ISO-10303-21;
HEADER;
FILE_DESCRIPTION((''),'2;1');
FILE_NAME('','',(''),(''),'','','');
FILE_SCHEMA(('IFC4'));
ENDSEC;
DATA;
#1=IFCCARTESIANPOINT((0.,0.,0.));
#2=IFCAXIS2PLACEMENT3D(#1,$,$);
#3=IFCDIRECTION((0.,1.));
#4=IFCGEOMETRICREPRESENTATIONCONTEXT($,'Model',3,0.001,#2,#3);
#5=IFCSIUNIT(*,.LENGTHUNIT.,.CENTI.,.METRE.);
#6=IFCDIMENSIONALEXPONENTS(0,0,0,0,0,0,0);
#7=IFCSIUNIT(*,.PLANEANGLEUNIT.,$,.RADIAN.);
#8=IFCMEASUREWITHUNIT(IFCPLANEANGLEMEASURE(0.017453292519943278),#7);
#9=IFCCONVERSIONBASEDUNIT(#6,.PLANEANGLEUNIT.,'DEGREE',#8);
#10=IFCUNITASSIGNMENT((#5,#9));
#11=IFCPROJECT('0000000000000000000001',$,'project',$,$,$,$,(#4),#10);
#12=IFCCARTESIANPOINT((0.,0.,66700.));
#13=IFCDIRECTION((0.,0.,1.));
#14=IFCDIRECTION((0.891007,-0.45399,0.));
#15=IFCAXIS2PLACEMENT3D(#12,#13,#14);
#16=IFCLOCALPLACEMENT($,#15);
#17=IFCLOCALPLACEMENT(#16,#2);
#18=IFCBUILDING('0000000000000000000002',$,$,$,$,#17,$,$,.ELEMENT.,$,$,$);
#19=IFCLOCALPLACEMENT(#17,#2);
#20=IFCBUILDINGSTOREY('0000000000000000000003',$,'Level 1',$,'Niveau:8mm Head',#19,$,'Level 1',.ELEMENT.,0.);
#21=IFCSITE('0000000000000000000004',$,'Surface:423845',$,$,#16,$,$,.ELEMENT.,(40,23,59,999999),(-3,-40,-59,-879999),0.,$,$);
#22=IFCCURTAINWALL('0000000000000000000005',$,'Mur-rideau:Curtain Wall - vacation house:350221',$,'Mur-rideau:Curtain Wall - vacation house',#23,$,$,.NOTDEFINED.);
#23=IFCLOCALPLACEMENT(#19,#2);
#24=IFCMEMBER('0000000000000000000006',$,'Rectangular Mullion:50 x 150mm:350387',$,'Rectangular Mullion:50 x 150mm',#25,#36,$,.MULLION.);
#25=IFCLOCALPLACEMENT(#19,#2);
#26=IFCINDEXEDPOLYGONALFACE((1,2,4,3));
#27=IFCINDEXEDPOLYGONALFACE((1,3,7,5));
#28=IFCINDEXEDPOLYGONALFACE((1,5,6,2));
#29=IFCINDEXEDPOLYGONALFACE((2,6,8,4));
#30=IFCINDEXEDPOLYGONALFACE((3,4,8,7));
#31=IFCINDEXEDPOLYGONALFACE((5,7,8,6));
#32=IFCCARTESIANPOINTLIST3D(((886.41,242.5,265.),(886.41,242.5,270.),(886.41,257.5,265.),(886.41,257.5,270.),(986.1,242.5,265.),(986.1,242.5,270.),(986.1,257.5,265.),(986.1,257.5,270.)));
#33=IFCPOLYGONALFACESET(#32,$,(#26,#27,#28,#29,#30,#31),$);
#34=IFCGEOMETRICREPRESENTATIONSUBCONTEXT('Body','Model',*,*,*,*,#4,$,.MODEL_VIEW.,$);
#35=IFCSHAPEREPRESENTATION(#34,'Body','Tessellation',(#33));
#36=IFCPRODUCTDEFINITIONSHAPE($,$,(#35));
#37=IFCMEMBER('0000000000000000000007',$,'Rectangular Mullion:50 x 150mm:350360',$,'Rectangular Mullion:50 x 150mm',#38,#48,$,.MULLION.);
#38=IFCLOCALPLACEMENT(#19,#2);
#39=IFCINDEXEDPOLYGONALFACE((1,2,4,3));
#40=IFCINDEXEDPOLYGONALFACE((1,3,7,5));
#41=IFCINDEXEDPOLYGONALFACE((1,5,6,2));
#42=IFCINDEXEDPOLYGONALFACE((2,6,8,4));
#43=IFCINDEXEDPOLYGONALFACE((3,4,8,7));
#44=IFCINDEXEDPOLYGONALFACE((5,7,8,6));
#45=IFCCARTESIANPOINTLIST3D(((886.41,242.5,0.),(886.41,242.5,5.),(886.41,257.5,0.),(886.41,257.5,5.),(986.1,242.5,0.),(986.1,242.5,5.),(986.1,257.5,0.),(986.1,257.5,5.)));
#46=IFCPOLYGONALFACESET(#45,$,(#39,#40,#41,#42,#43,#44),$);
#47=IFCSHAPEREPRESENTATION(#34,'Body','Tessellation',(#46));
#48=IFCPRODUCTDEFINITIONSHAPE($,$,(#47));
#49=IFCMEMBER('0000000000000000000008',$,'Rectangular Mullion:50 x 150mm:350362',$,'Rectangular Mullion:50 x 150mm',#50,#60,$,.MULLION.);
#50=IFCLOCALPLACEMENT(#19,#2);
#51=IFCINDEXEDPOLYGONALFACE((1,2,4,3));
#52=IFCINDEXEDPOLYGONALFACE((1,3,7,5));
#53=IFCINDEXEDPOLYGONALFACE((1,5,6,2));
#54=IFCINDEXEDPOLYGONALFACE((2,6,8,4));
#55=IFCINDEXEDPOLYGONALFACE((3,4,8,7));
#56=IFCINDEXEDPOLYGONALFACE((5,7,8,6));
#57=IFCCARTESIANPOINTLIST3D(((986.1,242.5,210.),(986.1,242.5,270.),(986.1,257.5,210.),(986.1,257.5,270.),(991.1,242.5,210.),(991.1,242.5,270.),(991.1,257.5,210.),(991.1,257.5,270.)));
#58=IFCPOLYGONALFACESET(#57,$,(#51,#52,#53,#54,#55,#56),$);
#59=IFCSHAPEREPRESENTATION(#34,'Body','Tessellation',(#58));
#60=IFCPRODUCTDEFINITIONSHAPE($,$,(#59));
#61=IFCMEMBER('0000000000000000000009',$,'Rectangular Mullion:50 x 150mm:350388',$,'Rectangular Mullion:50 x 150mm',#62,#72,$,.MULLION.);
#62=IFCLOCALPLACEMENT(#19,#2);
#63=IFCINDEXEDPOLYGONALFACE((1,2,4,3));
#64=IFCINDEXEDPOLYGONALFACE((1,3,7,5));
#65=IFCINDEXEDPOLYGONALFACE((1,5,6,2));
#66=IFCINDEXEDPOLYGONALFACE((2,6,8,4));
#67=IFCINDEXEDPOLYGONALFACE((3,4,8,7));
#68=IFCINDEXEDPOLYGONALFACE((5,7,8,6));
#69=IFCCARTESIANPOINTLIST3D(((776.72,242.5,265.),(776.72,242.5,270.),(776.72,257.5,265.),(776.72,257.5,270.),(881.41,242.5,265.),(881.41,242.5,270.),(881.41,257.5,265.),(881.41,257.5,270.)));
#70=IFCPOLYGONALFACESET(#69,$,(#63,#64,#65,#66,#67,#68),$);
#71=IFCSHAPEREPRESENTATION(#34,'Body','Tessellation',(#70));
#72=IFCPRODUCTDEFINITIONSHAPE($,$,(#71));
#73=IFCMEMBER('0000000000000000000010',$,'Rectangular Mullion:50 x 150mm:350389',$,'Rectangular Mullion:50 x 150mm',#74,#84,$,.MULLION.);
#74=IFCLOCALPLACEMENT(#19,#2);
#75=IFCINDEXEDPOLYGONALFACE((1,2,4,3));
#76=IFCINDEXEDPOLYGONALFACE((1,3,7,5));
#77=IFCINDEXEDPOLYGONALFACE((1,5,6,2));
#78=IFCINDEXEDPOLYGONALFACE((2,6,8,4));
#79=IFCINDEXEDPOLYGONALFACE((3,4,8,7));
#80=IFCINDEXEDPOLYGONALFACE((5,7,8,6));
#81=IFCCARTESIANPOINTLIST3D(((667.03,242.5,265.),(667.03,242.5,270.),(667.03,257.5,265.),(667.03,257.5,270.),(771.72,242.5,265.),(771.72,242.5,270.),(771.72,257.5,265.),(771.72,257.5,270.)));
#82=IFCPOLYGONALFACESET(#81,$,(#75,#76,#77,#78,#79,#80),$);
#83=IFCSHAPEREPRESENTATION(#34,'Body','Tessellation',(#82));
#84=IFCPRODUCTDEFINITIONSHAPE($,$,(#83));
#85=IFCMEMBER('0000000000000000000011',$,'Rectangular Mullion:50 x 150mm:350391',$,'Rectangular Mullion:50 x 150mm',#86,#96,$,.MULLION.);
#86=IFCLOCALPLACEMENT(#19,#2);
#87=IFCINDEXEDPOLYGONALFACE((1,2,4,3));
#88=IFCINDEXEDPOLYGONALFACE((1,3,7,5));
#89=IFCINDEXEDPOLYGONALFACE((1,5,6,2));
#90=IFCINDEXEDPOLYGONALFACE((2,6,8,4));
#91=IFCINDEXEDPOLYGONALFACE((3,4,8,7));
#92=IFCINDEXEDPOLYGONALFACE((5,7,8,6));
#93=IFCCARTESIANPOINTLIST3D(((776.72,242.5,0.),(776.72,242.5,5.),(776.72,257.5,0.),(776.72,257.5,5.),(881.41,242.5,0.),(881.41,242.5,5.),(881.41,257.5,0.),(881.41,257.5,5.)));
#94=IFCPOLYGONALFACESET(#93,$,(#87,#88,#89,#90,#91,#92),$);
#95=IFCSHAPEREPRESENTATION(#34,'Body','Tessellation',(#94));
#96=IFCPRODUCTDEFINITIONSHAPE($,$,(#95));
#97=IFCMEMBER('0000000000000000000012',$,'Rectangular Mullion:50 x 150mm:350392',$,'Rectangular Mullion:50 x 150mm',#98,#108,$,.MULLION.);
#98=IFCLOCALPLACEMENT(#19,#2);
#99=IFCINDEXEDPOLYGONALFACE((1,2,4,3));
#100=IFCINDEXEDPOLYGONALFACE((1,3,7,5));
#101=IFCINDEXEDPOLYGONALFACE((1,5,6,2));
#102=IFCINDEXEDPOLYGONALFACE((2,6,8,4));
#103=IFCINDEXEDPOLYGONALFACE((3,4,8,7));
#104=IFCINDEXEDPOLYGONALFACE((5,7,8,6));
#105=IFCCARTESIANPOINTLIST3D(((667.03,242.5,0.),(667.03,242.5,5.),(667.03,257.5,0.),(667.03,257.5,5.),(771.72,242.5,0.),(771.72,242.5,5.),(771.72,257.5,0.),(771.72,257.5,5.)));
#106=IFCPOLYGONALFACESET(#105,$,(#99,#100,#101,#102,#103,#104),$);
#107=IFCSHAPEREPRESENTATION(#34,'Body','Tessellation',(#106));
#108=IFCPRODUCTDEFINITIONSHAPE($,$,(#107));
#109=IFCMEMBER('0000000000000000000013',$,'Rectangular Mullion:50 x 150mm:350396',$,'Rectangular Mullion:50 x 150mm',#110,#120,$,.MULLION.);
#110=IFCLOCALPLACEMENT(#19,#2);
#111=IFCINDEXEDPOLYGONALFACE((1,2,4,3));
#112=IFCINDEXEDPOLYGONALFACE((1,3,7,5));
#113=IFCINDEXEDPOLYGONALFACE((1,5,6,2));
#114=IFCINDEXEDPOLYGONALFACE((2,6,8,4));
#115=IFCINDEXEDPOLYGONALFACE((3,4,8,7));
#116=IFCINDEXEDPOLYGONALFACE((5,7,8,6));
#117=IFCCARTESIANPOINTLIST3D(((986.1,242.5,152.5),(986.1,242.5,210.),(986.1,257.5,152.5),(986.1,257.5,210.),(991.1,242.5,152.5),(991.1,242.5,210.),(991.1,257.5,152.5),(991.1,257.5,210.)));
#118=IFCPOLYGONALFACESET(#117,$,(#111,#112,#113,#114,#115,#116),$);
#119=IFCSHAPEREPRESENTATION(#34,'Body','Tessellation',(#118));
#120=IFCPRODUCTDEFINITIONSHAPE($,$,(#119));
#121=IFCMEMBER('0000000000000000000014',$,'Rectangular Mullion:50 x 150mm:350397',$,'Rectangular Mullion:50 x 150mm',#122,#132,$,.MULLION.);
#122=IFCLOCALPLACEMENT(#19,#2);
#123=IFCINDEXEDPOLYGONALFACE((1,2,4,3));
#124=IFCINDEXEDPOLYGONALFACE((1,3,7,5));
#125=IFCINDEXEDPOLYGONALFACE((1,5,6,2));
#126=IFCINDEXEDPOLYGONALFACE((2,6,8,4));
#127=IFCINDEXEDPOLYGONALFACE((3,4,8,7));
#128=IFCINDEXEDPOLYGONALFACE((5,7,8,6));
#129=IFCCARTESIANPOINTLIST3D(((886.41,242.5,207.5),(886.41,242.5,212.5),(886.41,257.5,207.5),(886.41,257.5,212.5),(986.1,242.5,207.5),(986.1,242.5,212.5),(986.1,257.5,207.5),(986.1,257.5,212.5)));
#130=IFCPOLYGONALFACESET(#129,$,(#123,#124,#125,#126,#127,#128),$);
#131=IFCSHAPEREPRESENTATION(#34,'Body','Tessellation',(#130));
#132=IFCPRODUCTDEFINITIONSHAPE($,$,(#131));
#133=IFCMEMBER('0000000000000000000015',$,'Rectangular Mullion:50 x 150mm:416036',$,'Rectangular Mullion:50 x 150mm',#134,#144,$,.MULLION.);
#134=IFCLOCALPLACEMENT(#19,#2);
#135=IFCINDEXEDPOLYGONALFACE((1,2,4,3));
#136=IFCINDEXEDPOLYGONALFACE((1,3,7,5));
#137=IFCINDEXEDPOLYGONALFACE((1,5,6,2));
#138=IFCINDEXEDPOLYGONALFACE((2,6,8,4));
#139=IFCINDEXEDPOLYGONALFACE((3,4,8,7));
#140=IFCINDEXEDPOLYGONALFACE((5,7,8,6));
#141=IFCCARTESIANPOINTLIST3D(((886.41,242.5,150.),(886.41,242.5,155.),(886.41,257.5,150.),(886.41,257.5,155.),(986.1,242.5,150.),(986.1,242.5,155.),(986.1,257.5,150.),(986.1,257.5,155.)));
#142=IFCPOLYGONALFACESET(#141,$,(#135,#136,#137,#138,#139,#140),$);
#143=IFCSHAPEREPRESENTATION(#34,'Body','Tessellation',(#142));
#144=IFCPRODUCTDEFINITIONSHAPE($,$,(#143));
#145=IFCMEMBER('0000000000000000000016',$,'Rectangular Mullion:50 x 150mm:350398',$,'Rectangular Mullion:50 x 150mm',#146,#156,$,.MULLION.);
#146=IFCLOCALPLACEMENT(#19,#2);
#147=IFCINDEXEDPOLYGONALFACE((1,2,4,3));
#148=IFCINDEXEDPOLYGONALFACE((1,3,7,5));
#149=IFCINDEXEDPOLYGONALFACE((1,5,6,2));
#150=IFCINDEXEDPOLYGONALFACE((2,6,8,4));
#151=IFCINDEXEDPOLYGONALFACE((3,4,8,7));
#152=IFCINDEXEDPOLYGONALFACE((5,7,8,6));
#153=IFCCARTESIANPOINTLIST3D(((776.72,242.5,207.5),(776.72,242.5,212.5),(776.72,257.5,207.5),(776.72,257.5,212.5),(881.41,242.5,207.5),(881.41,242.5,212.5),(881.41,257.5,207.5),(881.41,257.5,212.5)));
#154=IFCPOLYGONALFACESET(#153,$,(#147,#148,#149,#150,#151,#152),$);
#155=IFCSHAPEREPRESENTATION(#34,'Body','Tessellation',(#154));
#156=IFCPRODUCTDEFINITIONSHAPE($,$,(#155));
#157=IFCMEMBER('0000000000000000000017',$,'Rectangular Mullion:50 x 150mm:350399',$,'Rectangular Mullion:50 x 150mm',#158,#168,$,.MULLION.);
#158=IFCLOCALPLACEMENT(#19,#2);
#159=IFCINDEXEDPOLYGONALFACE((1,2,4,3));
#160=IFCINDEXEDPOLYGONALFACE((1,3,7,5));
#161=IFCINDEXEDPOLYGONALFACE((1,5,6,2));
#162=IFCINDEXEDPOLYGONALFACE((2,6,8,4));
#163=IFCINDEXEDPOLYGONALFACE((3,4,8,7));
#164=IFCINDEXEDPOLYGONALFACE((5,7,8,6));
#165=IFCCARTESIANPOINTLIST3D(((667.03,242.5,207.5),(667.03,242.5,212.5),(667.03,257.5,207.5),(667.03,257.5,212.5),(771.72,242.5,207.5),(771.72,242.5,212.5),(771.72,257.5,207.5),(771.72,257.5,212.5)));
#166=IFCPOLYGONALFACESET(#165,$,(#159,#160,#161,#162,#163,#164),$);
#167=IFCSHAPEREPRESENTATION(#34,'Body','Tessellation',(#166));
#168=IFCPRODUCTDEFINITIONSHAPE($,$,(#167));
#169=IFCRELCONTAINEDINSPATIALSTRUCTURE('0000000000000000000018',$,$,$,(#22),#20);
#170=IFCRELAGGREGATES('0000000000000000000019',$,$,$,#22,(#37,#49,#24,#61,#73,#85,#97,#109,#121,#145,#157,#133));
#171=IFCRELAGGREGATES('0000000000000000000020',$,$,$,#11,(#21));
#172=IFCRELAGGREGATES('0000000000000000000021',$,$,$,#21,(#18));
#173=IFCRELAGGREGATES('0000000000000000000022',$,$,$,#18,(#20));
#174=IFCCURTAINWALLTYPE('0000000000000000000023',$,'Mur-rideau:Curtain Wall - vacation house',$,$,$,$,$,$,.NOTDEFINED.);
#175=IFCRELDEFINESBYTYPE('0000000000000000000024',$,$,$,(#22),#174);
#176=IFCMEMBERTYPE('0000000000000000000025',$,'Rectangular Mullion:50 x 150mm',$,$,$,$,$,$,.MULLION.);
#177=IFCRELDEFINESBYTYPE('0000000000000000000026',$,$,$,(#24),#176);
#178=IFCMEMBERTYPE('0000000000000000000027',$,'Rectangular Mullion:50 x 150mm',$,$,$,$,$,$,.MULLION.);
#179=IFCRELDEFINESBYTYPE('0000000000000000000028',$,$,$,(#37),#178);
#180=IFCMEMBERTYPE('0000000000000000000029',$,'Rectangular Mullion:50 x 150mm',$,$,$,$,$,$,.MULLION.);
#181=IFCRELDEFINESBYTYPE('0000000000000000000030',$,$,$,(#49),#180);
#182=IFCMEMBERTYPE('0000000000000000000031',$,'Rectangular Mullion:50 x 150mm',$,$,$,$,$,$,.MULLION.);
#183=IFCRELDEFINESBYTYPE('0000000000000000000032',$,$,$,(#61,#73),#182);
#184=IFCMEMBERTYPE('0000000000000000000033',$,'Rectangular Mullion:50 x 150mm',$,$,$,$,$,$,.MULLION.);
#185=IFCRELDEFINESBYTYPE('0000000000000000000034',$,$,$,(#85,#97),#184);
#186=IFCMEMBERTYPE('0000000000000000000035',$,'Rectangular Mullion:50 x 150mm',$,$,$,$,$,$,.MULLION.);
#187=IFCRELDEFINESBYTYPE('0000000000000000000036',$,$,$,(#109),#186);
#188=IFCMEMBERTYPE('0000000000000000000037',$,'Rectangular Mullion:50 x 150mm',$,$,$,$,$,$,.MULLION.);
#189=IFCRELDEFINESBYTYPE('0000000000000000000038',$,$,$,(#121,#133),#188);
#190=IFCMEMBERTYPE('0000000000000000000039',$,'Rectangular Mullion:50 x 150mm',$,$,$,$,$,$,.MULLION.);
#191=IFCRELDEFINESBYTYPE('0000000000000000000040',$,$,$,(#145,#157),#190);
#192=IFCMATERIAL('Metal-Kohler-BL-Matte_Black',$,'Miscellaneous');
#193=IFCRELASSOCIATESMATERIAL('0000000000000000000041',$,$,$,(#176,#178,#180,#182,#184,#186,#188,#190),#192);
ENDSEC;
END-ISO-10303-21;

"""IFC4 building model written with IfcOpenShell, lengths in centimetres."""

from ifc_helpers import new_model, entity, si_unit, converted_unit, direction, frame, origin, origin_2d_with_axis, place, context, subcontext, project, spatial, rectangle, extrude, source, transform, mapped, material, material_profile, profile_set, type_object, type_shapes, element, aggregate, save


model = new_model("IFC4")

# Units and contexts
model_context = context("Model", 3, precision=0.001, world=origin(), true_north=direction((0.0, 1.0)))
body_context = subcontext(model_context, "Body", "Model", "MODEL_VIEW")
ifc_project = project(units=[si_unit("LENGTHUNIT", "METRE", prefix="CENTI"), converted_unit("PLANEANGLEUNIT", "DEGREE", entity("IfcPlaneAngleMeasure", 0.017453292519943278), si_unit("PLANEANGLEUNIT", "RADIAN"), dimensions=[0, 0, 0, 0, 0, 0, 0])], contexts=[model_context])

# Site, building, storey
site_placement = place(None, frame((0.0, 0.0, 66700.0), z_axis=(0.0, 0.0, 1.0), x_axis=(0.891007, -0.45399, 0.0)))
site = spatial("IfcSite", under=ifc_project, at=site_placement, Name="Surface:423845", CompositionType="ELEMENT", RefLatitude=(40, 23, 59, 999999), RefLongitude=(-3, -40, -59, -879999), RefElevation=0.0)
building_placement = place(site_placement, origin())
building = spatial("IfcBuilding", under=site, at=building_placement, CompositionType="ELEMENT")
storey_placement = place(building_placement, origin())
storey = spatial("IfcBuildingStorey", under=building, at=storey_placement, Name="Level 1", ObjectType="Niveau:8mm Head", LongName="Level 1", CompositionType="ELEMENT", Elevation=0.0)

# Curtain wall, members
curtain_wall_type = type_object("IfcCurtainWallType", Name="Mur-rideau:Curtain Wall - vacation house", PredefinedType="NOTDEFINED")
curtain_wall_placement = place(storey_placement, origin())
curtain_wall = element("IfcCurtainWall", 1, at=curtain_wall_placement, inside=storey, type_object=curtain_wall_type, Name="Mur-rideau:Curtain Wall - vacation house:350221", ObjectType="Mur-rideau:Curtain Wall - vacation house", PredefinedType="NOTDEFINED")
ifc_material_1 = material(Name="Metal-Kohler-BL-Matte_Black", Category="Miscellaneous")
ifc_material_profile = material_profile(ifc_material_1, rectangle(XDim=5.0, YDim=15.0, at=origin_2d_with_axis()), Name="50 x 150mm")
ifc_profile_set = profile_set([ifc_material_profile], Name="50 x 150mm")
member_type_1 = type_object("IfcMemberType", Name="Rectangular Mullion:50 x 150mm", PredefinedType="MULLION", material=ifc_profile_set)
shared_shape_1 = source(origin(), body_context, "Body", "SweptSolid", [
    extrude(rectangle(XDim=5.0, YDim=15.0, at=origin_2d_with_axis()), frame((-2.5, 0.0, -99.69), z_axis=(0.0, 0.0, 1.0), x_axis=(-1.0, 0.0, 0.0)), (0.0, 0.0, 1.0), 99.69),
])
type_shapes(member_type_1, [shared_shape_1])
member_1_placement = place(curtain_wall_placement, frame((886.41, 250.0, 270.0), z_axis=(-1.0, 0.0, 0.0), x_axis=(0.0, 0.0, 1.0)))
member_1 = element("IfcMember", 2, at=member_1_placement, type_object=member_type_1, Name="Rectangular Mullion:50 x 150mm:350387", ObjectType="Rectangular Mullion:50 x 150mm", PredefinedType="MULLION", context=body_context, shape_type="MappedRepresentation", body=[
    mapped(shared_shape_1, transform((0.0, 0.0, 0.0), scale=1.0)),
])
member_type_2 = type_object("IfcMemberType", Name="Rectangular Mullion:50 x 150mm", PredefinedType="MULLION", material=ifc_profile_set)
shared_shape_2 = source(origin(), body_context, "Body", "SweptSolid", [
    extrude(rectangle(XDim=5.0, YDim=15.0, at=origin_2d_with_axis()), frame((-2.5, 0.0, -99.69), z_axis=(0.0, 0.0, 1.0), x_axis=(-1.0, 0.0, 0.0)), (0.0, 0.0, 1.0), 99.69),
])
type_shapes(member_type_2, [shared_shape_2])
member_2_placement = place(curtain_wall_placement, frame((986.1, 250.0, 0.0), z_axis=(1.0, 0.0, 0.0), x_axis=(0.0, 0.0, -1.0)))
member_2 = element("IfcMember", 3, at=member_2_placement, type_object=member_type_2, Name="Rectangular Mullion:50 x 150mm:350360", ObjectType="Rectangular Mullion:50 x 150mm", PredefinedType="MULLION", context=body_context, shape_type="MappedRepresentation", body=[
    mapped(shared_shape_2, transform((0.0, 0.0, 0.0), scale=1.0)),
])
member_type_3 = type_object("IfcMemberType", Name="Rectangular Mullion:50 x 150mm", PredefinedType="MULLION", material=ifc_profile_set)
shared_shape_3 = source(origin(), body_context, "Body", "SweptSolid", [
    extrude(rectangle(XDim=5.0, YDim=15.0, at=origin_2d_with_axis()), frame((-2.5, 0.0, -60.0), z_axis=(0.0, 0.0, 1.0), x_axis=(-1.0, 0.0, 0.0)), (0.0, 0.0, 1.0), 60.0),
])
type_shapes(member_type_3, [shared_shape_3])
member_3_placement = place(curtain_wall_placement, frame((991.1, 250.0, 270.0)))
member_3 = element("IfcMember", 4, at=member_3_placement, type_object=member_type_3, Name="Rectangular Mullion:50 x 150mm:350362", ObjectType="Rectangular Mullion:50 x 150mm", PredefinedType="MULLION", context=body_context, shape_type="MappedRepresentation", body=[
    mapped(shared_shape_3, transform((0.0, 0.0, 0.0), scale=1.0)),
])
member_type_4 = type_object("IfcMemberType", Name="Rectangular Mullion:50 x 150mm", PredefinedType="MULLION", material=ifc_profile_set)
shared_shape_4 = source(origin(), body_context, "Body", "SweptSolid", [
    extrude(rectangle(XDim=5.0, YDim=15.0, at=origin_2d_with_axis()), frame((-2.5, 0.0, -104.69), z_axis=(0.0, 0.0, 1.0), x_axis=(-1.0, 0.0, 0.0)), (0.0, 0.0, 1.0), 104.69),
])
type_shapes(member_type_4, [shared_shape_4])
member_4_placement = place(curtain_wall_placement, frame((776.72, 250.0, 270.0), z_axis=(-1.0, 0.0, 0.0), x_axis=(0.0, 0.0, 1.0)))
member_4 = element("IfcMember", 5, at=member_4_placement, type_object=member_type_4, Name="Rectangular Mullion:50 x 150mm:350388", ObjectType="Rectangular Mullion:50 x 150mm", PredefinedType="MULLION", context=body_context, shape_type="MappedRepresentation", body=[
    mapped(shared_shape_4, transform((0.0, 0.0, 0.0), scale=1.0)),
])
member_5_placement = place(curtain_wall_placement, frame((667.03, 250.0, 270.0), z_axis=(-1.0, 0.0, 0.0), x_axis=(0.0, 0.0, 1.0)))
member_5 = element("IfcMember", 6, at=member_5_placement, type_object=member_type_4, Name="Rectangular Mullion:50 x 150mm:350389", ObjectType="Rectangular Mullion:50 x 150mm", PredefinedType="MULLION", context=body_context, shape_type="MappedRepresentation", body=[
    mapped(shared_shape_4, transform((0.0, 0.0, 0.0), scale=1.0)),
])
member_type_5 = type_object("IfcMemberType", Name="Rectangular Mullion:50 x 150mm", PredefinedType="MULLION", material=ifc_profile_set)
shared_shape_5 = source(origin(), body_context, "Body", "SweptSolid", [
    extrude(rectangle(XDim=5.0, YDim=15.0, at=origin_2d_with_axis()), frame((-2.5, 0.0, -104.69), z_axis=(0.0, 0.0, 1.0), x_axis=(-1.0, 0.0, 0.0)), (0.0, 0.0, 1.0), 104.69),
])
type_shapes(member_type_5, [shared_shape_5])
member_6_placement = place(curtain_wall_placement, frame((881.41, 250.0, 0.0), z_axis=(1.0, 0.0, 0.0), x_axis=(0.0, 0.0, -1.0)))
member_6 = element("IfcMember", 7, at=member_6_placement, type_object=member_type_5, Name="Rectangular Mullion:50 x 150mm:350391", ObjectType="Rectangular Mullion:50 x 150mm", PredefinedType="MULLION", context=body_context, shape_type="MappedRepresentation", body=[
    mapped(shared_shape_5, transform((0.0, 0.0, 0.0), scale=1.0)),
])
member_7_placement = place(curtain_wall_placement, frame((771.72, 250.0, 0.0), z_axis=(1.0, 0.0, 0.0), x_axis=(0.0, 0.0, -1.0)))
member_7 = element("IfcMember", 8, at=member_7_placement, type_object=member_type_5, Name="Rectangular Mullion:50 x 150mm:350392", ObjectType="Rectangular Mullion:50 x 150mm", PredefinedType="MULLION", context=body_context, shape_type="MappedRepresentation", body=[
    mapped(shared_shape_5, transform((0.0, 0.0, 0.0), scale=1.0)),
])
member_type_6 = type_object("IfcMemberType", Name="Rectangular Mullion:50 x 150mm", PredefinedType="MULLION", material=ifc_profile_set)
shared_shape_6 = source(origin(), body_context, "Body", "SweptSolid", [
    extrude(rectangle(XDim=5.0, YDim=15.0, at=origin_2d_with_axis()), frame((-2.5, 0.0, -57.5), z_axis=(0.0, 0.0, 1.0), x_axis=(-1.0, 0.0, 0.0)), (0.0, 0.0, 1.0), 57.5),
])
type_shapes(member_type_6, [shared_shape_6])
member_8_placement = place(curtain_wall_placement, frame((991.1, 250.0, 210.0)))
member_8 = element("IfcMember", 9, at=member_8_placement, type_object=member_type_6, Name="Rectangular Mullion:50 x 150mm:350396", ObjectType="Rectangular Mullion:50 x 150mm", PredefinedType="MULLION", context=body_context, shape_type="MappedRepresentation", body=[
    mapped(shared_shape_6, transform((0.0, 0.0, 0.0), scale=1.0)),
])
member_type_7 = type_object("IfcMemberType", Name="Rectangular Mullion:50 x 150mm", PredefinedType="MULLION", material=ifc_profile_set)
shared_shape_7 = source(origin(), body_context, "Body", "SweptSolid", [
    extrude(rectangle(XDim=5.0, YDim=15.0, at=origin_2d_with_axis()), frame((0.0, 0.0, -99.69), z_axis=(0.0, 0.0, 1.0), x_axis=(-1.0, 0.0, 0.0)), (0.0, 0.0, 1.0), 99.69),
])
type_shapes(member_type_7, [shared_shape_7])
member_9_placement = place(curtain_wall_placement, frame((886.41, 250.0, 210.0), z_axis=(-1.0, 0.0, 0.0), x_axis=(0.0, 0.0, 1.0)))
member_9 = element("IfcMember", 10, at=member_9_placement, type_object=member_type_7, Name="Rectangular Mullion:50 x 150mm:350397", ObjectType="Rectangular Mullion:50 x 150mm", PredefinedType="MULLION", context=body_context, shape_type="MappedRepresentation", body=[
    mapped(shared_shape_7, transform((0.0, 0.0, 0.0), scale=1.0)),
])
member_10_placement = place(curtain_wall_placement, frame((886.41, 250.0, 152.5), z_axis=(-1.0, 0.0, 0.0), x_axis=(0.0, 0.0, 1.0)))
member_10 = element("IfcMember", 11, at=member_10_placement, type_object=member_type_7, Name="Rectangular Mullion:50 x 150mm:416036", ObjectType="Rectangular Mullion:50 x 150mm", PredefinedType="MULLION", context=body_context, shape_type="MappedRepresentation", body=[
    mapped(shared_shape_7, transform((0.0, 0.0, 0.0), scale=1.0)),
])
member_type_8 = type_object("IfcMemberType", Name="Rectangular Mullion:50 x 150mm", PredefinedType="MULLION", material=ifc_profile_set)
shared_shape_8 = source(origin(), body_context, "Body", "SweptSolid", [
    extrude(rectangle(XDim=5.0, YDim=15.0, at=origin_2d_with_axis()), frame((0.0, 0.0, -104.69), z_axis=(0.0, 0.0, 1.0), x_axis=(-1.0, 0.0, 0.0)), (0.0, 0.0, 1.0), 104.69),
])
type_shapes(member_type_8, [shared_shape_8])
member_11_placement = place(curtain_wall_placement, frame((776.72, 250.0, 210.0), z_axis=(-1.0, 0.0, 0.0), x_axis=(0.0, 0.0, 1.0)))
member_11 = element("IfcMember", 12, at=member_11_placement, type_object=member_type_8, Name="Rectangular Mullion:50 x 150mm:350398", ObjectType="Rectangular Mullion:50 x 150mm", PredefinedType="MULLION", context=body_context, shape_type="MappedRepresentation", body=[
    mapped(shared_shape_8, transform((0.0, 0.0, 0.0), scale=1.0)),
])
member_12_placement = place(curtain_wall_placement, frame((667.03, 250.0, 210.0), z_axis=(-1.0, 0.0, 0.0), x_axis=(0.0, 0.0, 1.0)))
member_12 = element("IfcMember", 13, at=member_12_placement, type_object=member_type_8, Name="Rectangular Mullion:50 x 150mm:350399", ObjectType="Rectangular Mullion:50 x 150mm", PredefinedType="MULLION", context=body_context, shape_type="MappedRepresentation", body=[
    mapped(shared_shape_8, transform((0.0, 0.0, 0.0), scale=1.0)),
])
aggregate(curtain_wall, [member_2, member_3, member_1, member_4, member_5, member_6, member_7, member_8, member_9, member_11, member_12, member_10])

save(model, "model.ifc")
